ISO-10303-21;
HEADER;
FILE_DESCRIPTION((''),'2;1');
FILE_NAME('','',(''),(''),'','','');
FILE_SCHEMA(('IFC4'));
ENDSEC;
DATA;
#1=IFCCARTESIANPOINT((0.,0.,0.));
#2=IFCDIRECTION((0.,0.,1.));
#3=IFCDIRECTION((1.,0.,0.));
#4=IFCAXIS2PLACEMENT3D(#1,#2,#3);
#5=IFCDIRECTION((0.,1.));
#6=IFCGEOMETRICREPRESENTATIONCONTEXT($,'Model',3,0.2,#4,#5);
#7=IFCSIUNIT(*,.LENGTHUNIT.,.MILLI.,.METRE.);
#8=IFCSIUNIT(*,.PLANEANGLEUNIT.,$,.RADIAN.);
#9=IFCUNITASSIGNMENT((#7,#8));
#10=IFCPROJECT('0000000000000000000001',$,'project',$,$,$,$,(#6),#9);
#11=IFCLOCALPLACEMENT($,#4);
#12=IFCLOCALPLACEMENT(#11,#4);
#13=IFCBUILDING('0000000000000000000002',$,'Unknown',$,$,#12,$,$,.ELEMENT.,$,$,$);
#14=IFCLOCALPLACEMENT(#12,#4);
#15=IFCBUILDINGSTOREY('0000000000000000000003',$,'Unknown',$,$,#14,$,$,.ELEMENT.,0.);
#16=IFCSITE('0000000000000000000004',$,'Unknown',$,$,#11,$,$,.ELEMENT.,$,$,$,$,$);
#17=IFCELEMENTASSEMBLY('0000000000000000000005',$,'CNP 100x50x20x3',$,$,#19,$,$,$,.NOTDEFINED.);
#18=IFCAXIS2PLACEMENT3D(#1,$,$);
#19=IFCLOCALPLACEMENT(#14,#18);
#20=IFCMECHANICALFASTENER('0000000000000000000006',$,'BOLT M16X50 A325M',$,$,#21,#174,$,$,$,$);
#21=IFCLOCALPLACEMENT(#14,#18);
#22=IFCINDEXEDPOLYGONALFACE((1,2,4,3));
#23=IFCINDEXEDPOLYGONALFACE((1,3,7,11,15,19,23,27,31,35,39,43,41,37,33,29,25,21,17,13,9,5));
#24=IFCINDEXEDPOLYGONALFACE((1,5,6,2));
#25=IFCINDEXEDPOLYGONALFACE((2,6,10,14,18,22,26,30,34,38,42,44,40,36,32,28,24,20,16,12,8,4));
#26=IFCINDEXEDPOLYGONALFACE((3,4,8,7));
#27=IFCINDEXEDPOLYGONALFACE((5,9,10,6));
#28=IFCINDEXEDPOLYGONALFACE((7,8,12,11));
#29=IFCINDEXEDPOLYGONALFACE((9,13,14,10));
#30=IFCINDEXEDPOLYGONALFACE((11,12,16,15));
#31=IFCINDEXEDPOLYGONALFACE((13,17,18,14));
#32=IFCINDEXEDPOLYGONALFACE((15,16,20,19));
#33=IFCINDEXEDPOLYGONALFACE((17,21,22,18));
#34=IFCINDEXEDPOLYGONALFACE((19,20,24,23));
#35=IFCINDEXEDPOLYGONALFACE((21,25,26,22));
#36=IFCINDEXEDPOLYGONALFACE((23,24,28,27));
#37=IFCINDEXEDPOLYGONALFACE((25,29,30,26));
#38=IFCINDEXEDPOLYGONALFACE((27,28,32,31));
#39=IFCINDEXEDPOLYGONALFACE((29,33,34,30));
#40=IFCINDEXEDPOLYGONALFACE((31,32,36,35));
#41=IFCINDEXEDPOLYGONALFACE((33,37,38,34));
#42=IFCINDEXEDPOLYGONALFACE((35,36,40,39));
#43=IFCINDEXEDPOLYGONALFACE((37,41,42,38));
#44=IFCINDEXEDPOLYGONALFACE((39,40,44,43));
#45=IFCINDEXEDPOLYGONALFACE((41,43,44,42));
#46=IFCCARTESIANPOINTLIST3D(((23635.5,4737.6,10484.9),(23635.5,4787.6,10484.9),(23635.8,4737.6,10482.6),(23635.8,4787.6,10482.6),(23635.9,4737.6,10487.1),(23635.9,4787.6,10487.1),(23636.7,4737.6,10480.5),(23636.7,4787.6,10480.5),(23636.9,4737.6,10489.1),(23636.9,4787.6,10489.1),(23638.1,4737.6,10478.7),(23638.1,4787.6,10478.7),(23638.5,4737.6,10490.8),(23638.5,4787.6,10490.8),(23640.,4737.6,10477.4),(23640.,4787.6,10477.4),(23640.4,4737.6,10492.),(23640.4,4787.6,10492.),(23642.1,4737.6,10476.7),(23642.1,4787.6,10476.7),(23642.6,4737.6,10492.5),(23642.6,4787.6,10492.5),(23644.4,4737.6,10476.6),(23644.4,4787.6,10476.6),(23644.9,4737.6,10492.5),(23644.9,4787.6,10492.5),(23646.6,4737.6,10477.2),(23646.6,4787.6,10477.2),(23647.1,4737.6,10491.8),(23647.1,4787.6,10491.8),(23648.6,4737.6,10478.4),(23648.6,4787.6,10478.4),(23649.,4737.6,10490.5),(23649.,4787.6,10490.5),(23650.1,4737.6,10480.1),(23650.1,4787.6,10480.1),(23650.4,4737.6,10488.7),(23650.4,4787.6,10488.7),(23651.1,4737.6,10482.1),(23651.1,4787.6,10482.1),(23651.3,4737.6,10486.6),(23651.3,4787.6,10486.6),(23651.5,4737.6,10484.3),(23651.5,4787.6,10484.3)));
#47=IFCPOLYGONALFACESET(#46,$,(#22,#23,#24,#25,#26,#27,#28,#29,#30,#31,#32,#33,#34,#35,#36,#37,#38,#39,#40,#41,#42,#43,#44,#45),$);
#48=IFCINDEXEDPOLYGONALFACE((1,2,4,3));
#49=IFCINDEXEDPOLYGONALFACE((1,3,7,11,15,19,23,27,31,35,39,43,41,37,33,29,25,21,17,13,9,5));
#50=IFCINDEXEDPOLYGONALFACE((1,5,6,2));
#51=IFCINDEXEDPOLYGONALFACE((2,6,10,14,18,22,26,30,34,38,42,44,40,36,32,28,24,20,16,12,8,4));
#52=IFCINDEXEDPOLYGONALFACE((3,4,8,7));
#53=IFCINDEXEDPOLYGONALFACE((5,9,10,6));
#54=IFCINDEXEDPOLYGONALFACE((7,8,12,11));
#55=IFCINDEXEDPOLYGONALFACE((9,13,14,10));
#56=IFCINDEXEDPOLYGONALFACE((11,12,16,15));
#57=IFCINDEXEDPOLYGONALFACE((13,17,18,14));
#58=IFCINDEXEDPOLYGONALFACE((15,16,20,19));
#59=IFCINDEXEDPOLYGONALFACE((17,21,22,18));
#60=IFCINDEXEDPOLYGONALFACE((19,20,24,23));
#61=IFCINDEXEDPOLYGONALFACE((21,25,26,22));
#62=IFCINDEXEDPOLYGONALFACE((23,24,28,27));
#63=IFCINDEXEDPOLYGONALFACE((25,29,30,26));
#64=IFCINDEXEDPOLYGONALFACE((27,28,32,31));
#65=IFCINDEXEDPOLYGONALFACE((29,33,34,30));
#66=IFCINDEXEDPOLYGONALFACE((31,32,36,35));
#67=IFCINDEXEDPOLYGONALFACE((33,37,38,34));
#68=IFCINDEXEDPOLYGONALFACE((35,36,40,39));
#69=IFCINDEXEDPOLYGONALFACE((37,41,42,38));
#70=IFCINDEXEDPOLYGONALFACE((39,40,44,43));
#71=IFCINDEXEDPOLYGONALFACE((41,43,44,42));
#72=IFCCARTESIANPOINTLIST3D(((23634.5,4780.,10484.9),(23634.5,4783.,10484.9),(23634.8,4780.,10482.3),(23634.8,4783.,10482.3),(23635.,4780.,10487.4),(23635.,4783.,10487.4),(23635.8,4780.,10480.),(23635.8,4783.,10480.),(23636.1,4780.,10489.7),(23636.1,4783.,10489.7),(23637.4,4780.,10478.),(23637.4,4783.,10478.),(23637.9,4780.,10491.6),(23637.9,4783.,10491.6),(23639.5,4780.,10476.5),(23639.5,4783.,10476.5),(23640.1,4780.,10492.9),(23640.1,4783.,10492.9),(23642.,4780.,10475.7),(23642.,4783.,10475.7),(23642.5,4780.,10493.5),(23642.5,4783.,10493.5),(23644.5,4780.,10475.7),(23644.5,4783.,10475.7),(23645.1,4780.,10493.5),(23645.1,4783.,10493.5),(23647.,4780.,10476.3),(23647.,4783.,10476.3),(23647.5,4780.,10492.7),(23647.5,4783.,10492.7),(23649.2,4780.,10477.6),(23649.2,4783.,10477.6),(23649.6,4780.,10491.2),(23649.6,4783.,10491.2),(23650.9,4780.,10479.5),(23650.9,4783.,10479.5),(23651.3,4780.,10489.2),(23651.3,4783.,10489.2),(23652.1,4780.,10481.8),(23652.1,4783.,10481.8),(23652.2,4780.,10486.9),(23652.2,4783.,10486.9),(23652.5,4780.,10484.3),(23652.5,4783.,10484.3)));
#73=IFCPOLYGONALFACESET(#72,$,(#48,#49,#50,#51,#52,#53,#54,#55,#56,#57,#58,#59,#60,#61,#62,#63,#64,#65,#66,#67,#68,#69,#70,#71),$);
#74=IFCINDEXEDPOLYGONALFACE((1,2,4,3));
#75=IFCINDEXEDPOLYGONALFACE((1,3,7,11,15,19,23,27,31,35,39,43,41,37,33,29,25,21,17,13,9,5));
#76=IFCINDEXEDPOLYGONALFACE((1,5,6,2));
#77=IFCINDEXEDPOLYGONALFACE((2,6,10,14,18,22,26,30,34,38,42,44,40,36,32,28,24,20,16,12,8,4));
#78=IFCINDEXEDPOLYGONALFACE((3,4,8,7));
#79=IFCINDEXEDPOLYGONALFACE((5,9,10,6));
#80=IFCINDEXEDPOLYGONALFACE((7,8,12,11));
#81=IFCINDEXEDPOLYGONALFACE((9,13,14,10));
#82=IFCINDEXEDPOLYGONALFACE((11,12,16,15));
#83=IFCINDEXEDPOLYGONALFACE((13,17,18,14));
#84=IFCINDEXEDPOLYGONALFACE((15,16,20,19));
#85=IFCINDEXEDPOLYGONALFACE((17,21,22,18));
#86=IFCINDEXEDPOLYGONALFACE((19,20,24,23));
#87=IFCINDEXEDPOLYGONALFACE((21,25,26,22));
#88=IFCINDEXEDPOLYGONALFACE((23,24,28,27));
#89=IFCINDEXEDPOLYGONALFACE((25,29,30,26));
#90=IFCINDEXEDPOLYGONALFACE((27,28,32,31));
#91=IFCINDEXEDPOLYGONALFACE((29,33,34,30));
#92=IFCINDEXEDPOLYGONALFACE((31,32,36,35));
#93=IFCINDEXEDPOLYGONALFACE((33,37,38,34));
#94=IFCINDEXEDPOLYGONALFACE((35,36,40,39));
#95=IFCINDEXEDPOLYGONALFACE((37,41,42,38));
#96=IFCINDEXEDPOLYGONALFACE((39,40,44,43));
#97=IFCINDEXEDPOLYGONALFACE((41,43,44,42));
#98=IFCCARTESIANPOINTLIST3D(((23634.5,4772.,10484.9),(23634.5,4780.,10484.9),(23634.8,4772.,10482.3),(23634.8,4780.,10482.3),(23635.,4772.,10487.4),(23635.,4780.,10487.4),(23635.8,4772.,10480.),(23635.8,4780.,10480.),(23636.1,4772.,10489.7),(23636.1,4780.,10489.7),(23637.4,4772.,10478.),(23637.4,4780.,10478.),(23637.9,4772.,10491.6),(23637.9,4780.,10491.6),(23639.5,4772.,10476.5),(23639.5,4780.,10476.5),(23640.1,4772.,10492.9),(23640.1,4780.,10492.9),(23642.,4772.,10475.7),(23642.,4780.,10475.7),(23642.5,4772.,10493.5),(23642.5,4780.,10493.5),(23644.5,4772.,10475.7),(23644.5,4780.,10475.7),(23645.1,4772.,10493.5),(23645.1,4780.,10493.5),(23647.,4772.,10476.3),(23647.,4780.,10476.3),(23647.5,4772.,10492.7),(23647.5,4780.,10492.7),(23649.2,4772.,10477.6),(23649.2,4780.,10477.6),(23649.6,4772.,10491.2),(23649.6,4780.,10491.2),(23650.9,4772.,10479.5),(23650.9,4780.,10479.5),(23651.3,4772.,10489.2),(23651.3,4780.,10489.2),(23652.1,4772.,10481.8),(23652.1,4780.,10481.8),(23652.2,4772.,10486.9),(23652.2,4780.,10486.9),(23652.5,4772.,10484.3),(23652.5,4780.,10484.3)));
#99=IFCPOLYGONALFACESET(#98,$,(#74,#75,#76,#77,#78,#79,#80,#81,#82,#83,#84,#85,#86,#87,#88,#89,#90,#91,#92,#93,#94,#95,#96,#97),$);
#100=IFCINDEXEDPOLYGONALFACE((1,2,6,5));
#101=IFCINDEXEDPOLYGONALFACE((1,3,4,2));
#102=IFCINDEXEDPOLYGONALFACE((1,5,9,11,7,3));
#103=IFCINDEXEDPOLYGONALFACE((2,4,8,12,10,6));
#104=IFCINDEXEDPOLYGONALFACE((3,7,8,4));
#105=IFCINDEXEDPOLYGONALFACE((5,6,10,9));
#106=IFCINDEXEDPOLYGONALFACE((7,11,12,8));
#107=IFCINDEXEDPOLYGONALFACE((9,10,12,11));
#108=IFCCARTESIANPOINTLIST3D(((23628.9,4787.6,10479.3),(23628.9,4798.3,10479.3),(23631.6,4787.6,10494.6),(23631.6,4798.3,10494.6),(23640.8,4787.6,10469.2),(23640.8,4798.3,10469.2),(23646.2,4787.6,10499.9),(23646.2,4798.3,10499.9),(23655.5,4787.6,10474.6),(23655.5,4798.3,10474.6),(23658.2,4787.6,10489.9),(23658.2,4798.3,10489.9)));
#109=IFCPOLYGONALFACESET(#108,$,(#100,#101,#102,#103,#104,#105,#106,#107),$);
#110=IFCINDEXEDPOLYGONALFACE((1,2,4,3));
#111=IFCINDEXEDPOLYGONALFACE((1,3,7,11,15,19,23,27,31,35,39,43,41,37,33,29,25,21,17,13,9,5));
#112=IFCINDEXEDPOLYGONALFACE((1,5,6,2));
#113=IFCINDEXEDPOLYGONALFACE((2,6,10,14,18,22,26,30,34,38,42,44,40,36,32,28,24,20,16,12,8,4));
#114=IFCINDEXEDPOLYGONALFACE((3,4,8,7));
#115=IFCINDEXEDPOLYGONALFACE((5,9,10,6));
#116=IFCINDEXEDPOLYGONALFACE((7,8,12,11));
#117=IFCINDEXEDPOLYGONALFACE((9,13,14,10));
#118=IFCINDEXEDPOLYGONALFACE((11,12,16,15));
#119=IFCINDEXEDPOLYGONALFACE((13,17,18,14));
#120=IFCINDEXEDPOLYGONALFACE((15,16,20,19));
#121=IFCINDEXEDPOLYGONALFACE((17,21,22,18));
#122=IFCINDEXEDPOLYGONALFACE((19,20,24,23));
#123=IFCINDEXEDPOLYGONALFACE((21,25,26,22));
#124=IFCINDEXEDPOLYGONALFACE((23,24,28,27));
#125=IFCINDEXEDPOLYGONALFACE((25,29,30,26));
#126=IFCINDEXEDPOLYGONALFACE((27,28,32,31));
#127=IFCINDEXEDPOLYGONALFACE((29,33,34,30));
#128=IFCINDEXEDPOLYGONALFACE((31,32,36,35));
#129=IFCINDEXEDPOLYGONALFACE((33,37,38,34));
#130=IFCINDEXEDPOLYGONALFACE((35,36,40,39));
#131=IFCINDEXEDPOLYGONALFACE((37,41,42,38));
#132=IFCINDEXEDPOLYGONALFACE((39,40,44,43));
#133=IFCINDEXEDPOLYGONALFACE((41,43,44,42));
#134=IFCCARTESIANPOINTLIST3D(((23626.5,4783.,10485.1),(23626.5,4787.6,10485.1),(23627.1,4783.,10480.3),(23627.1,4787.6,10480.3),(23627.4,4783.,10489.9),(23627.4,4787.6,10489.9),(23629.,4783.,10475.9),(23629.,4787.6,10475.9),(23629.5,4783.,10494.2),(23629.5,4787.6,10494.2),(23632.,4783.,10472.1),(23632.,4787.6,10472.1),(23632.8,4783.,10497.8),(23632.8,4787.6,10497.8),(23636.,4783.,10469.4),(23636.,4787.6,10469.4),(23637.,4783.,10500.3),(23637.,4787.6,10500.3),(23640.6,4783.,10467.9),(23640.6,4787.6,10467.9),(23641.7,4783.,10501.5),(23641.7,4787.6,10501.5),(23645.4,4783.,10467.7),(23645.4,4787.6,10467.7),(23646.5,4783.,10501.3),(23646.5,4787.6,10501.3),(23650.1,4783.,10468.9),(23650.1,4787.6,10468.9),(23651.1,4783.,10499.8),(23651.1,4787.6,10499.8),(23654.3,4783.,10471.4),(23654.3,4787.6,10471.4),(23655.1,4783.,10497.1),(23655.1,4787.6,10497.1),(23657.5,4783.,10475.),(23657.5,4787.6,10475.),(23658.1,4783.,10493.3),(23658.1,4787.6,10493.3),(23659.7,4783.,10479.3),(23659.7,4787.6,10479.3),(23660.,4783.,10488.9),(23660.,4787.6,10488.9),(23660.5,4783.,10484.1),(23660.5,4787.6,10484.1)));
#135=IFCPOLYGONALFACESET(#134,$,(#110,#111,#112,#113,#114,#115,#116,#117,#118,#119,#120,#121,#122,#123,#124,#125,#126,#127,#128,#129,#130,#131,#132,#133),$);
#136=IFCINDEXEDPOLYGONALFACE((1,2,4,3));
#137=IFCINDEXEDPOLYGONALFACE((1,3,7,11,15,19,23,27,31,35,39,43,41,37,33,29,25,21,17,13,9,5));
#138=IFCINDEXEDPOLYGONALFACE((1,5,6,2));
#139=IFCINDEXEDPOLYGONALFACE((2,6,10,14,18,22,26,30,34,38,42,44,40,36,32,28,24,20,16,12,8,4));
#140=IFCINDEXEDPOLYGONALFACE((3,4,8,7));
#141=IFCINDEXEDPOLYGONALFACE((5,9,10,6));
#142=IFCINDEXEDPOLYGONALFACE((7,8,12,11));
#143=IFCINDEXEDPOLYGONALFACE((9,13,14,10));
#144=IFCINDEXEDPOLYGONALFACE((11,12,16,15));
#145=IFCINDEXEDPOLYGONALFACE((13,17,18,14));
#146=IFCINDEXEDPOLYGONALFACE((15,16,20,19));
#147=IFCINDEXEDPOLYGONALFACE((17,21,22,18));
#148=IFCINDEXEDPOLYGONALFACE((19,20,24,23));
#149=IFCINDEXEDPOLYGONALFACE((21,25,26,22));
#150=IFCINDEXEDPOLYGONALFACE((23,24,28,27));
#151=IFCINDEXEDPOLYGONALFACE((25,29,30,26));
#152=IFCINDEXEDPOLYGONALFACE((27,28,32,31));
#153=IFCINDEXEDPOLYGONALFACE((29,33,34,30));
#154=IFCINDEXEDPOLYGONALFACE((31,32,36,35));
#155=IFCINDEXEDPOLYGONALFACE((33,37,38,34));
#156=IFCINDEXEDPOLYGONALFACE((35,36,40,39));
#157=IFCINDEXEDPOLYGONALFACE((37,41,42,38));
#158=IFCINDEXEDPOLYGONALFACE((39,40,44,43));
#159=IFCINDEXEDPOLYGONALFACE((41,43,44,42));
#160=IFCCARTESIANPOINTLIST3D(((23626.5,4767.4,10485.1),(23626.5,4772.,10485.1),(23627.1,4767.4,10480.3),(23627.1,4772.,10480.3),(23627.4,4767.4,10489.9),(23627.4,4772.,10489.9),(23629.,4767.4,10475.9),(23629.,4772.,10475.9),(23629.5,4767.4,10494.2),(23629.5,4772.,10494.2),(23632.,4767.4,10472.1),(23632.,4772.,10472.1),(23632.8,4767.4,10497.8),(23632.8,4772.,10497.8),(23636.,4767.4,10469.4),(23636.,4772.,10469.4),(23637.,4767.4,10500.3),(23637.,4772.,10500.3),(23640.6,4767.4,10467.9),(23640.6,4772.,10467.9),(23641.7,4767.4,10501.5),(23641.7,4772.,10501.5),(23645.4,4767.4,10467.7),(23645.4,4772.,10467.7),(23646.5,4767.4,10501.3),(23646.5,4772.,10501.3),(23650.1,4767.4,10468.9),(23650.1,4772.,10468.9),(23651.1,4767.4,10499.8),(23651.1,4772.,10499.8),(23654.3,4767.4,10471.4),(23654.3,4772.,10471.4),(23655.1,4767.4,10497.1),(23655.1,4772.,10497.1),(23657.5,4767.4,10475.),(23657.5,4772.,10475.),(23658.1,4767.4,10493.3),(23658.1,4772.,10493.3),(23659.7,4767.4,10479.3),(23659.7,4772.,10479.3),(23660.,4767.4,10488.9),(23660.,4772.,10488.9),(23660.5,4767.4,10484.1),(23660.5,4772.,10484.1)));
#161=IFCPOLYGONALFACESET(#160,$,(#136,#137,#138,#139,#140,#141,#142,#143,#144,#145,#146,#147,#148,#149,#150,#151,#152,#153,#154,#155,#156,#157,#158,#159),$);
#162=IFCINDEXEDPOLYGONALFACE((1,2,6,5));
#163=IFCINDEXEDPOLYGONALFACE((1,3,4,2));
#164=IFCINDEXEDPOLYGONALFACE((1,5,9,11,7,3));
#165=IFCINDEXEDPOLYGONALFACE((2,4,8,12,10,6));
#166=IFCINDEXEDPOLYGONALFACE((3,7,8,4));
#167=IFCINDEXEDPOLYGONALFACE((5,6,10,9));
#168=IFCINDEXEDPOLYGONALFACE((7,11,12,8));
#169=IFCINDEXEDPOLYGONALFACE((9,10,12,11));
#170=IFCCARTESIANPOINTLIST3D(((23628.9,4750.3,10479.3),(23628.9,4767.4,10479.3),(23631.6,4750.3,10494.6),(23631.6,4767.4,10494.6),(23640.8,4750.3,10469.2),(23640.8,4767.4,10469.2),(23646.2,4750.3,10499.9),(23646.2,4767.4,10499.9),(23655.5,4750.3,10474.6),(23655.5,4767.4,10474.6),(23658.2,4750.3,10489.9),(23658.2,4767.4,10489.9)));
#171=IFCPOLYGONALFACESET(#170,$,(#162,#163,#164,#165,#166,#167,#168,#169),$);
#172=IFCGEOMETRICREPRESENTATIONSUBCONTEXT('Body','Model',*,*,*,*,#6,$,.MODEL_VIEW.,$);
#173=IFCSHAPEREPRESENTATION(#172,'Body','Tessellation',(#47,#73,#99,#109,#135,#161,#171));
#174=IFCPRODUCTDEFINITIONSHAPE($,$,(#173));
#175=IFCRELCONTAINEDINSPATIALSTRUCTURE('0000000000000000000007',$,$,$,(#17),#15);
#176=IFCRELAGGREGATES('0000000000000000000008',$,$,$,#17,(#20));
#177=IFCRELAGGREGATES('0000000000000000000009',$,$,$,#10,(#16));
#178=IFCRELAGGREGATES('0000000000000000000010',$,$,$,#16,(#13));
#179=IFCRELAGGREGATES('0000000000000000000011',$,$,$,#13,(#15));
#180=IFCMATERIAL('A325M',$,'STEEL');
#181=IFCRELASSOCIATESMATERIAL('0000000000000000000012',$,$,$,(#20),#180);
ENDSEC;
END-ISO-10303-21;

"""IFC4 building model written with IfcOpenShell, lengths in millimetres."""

from ifc_helpers import new_model, si_unit, direction, frame, origin_with_axes, place, context, subcontext, project, spatial, line, arc, indexed_curve, outline, extrude, source, transform, mapped, material, element, aggregate, save


model = new_model("IFC4")

# Units and contexts
model_context = context("Model", 3, precision=0.2, world=origin_with_axes(), true_north=direction((0.0, 1.0)))
body_context = subcontext(model_context, "Body", "Model", "MODEL_VIEW")
ifc_project = project(units=[si_unit("LENGTHUNIT", "METRE", prefix="MILLI"), si_unit("PLANEANGLEUNIT", "RADIAN")], contexts=[model_context])

# Site, building, storey
site_placement = place(None, origin_with_axes())
site = spatial("IfcSite", under=ifc_project, at=site_placement, Name="Unknown", CompositionType="ELEMENT")
building_placement = place(site_placement, origin_with_axes())
building = spatial("IfcBuilding", under=site, at=building_placement, Name="Unknown", CompositionType="ELEMENT")
storey_placement = place(building_placement, origin_with_axes())
storey = spatial("IfcBuildingStorey", under=building, at=storey_placement, Name="Unknown", CompositionType="ELEMENT", Elevation=0.0)

# Shared definitions
ifc_material_1 = material(Name="A325M", Category="STEEL")
shared_shape = source(origin_with_axes(), body_context, "Body", "SweptSolid", [
    extrude(outline(indexed_curve([(8.0, 0.0), (0.0, 8.0), (-8.0, 0.0), (0.0, -8.0)], segments=[arc(1, 2, 3), arc(3, 4, 1)])), frame((0.0, 0.0, 15.6), z_axis=(0.0, 0.0, -1.0), x_axis=(0.0, 1.0, 0.0)), (0.0, 0.0, 1.0), 50.0),
    extrude(outline(indexed_curve([(9.0, 0.0), (0.0, 9.0), (-9.0, 0.0), (0.0, -9.0)], segments=[arc(1, 2, 3), arc(3, 4, 1)])), frame((0.0, 0.0, 11.0), z_axis=(0.0, 0.0, -1.0), x_axis=(0.0, 1.0, 0.0)), (0.0, 0.0, 1.0), 3.0),
    extrude(outline(indexed_curve([(9.0, 0.0), (0.0, 9.0), (-9.0, 0.0), (0.0, -9.0)], segments=[arc(1, 2, 3), arc(3, 4, 1)])), frame((0.0, 0.0, 8.0), z_axis=(0.0, 0.0, -1.0), x_axis=(0.0, 1.0, 0.0)), (0.0, 0.0, 1.0), 8.0),
    extrude(outline(indexed_curve([(15.6, 0.0), (7.8, 13.5), (-7.8, 13.5), (-15.6, 0.0), (-7.8, -13.5), (7.8, -13.5)], segments=[line(1, 2, 3, 4, 5, 6, 1)])), frame((0.0, 0.0, 26.4), z_axis=(0.0, 0.0, -1.0), x_axis=(0.0, 1.0, 0.0)), (0.0, 0.0, 1.0), 10.8),
    extrude(outline(indexed_curve([(17.0, 0.0), (0.0, 17.0), (-17.0, 0.0), (0.0, -17.0)], segments=[arc(1, 2, 3), arc(3, 4, 1)])), frame((0.0, 0.0, 15.6), z_axis=(0.0, 0.0, -1.0), x_axis=(0.0, 1.0, 0.0)), (0.0, 0.0, 1.0), 4.6),
    extrude(outline(indexed_curve([(17.0, 0.0), (0.0, 17.0), (-17.0, 0.0), (0.0, -17.0)], segments=[arc(1, 2, 3), arc(3, 4, 1)])), frame((0.0, 0.0, 0.0), z_axis=(0.0, 0.0, -1.0), x_axis=(0.0, 1.0, 0.0)), (0.0, 0.0, 1.0), 4.6),
    extrude(outline(indexed_curve([(15.6, 0.0), (7.8, 13.5), (-7.8, 13.5), (-15.6, 0.0), (-7.8, -13.5), (7.8, -13.5)], segments=[line(1, 2, 3, 4, 5, 6, 1)])), frame((0.0, 0.0, -4.6), z_axis=(0.0, 0.0, -1.0), x_axis=(0.0, 1.0, 0.0)), (0.0, 0.0, 1.0), 17.1),
])

# Element assembly, mechanical fastener
assembly_1_placement = place(storey_placement, frame((25552.5, 4805.0, 10153.1), z_axis=(0.173648, 0.0, 0.984808), x_axis=(-0.984808, 0.0, 0.173648)))
assembly_1 = element("IfcElementAssembly", 1, at=assembly_1_placement, inside=storey, Name="CNP 100x50x20x3", PredefinedType="NOTDEFINED")
mechanical_fastener_1_placement = place(assembly_1_placement, frame((1937.5, 33.0, -5.0), z_axis=(0.0, -1.0, 0.0), x_axis=(-1.0, 0.0, 0.0)))
mechanical_fastener_1 = element("IfcMechanicalFastener", 2, at=mechanical_fastener_1_placement, material=ifc_material_1, Name="BOLT M16X50 A325M", context=body_context, shape_type="MappedRepresentation", body=[
    mapped(shared_shape, transform((0.0, 0.0, 0.0))),
])
aggregate(assembly_1, [mechanical_fastener_1])

save(model, "model.ifc")
